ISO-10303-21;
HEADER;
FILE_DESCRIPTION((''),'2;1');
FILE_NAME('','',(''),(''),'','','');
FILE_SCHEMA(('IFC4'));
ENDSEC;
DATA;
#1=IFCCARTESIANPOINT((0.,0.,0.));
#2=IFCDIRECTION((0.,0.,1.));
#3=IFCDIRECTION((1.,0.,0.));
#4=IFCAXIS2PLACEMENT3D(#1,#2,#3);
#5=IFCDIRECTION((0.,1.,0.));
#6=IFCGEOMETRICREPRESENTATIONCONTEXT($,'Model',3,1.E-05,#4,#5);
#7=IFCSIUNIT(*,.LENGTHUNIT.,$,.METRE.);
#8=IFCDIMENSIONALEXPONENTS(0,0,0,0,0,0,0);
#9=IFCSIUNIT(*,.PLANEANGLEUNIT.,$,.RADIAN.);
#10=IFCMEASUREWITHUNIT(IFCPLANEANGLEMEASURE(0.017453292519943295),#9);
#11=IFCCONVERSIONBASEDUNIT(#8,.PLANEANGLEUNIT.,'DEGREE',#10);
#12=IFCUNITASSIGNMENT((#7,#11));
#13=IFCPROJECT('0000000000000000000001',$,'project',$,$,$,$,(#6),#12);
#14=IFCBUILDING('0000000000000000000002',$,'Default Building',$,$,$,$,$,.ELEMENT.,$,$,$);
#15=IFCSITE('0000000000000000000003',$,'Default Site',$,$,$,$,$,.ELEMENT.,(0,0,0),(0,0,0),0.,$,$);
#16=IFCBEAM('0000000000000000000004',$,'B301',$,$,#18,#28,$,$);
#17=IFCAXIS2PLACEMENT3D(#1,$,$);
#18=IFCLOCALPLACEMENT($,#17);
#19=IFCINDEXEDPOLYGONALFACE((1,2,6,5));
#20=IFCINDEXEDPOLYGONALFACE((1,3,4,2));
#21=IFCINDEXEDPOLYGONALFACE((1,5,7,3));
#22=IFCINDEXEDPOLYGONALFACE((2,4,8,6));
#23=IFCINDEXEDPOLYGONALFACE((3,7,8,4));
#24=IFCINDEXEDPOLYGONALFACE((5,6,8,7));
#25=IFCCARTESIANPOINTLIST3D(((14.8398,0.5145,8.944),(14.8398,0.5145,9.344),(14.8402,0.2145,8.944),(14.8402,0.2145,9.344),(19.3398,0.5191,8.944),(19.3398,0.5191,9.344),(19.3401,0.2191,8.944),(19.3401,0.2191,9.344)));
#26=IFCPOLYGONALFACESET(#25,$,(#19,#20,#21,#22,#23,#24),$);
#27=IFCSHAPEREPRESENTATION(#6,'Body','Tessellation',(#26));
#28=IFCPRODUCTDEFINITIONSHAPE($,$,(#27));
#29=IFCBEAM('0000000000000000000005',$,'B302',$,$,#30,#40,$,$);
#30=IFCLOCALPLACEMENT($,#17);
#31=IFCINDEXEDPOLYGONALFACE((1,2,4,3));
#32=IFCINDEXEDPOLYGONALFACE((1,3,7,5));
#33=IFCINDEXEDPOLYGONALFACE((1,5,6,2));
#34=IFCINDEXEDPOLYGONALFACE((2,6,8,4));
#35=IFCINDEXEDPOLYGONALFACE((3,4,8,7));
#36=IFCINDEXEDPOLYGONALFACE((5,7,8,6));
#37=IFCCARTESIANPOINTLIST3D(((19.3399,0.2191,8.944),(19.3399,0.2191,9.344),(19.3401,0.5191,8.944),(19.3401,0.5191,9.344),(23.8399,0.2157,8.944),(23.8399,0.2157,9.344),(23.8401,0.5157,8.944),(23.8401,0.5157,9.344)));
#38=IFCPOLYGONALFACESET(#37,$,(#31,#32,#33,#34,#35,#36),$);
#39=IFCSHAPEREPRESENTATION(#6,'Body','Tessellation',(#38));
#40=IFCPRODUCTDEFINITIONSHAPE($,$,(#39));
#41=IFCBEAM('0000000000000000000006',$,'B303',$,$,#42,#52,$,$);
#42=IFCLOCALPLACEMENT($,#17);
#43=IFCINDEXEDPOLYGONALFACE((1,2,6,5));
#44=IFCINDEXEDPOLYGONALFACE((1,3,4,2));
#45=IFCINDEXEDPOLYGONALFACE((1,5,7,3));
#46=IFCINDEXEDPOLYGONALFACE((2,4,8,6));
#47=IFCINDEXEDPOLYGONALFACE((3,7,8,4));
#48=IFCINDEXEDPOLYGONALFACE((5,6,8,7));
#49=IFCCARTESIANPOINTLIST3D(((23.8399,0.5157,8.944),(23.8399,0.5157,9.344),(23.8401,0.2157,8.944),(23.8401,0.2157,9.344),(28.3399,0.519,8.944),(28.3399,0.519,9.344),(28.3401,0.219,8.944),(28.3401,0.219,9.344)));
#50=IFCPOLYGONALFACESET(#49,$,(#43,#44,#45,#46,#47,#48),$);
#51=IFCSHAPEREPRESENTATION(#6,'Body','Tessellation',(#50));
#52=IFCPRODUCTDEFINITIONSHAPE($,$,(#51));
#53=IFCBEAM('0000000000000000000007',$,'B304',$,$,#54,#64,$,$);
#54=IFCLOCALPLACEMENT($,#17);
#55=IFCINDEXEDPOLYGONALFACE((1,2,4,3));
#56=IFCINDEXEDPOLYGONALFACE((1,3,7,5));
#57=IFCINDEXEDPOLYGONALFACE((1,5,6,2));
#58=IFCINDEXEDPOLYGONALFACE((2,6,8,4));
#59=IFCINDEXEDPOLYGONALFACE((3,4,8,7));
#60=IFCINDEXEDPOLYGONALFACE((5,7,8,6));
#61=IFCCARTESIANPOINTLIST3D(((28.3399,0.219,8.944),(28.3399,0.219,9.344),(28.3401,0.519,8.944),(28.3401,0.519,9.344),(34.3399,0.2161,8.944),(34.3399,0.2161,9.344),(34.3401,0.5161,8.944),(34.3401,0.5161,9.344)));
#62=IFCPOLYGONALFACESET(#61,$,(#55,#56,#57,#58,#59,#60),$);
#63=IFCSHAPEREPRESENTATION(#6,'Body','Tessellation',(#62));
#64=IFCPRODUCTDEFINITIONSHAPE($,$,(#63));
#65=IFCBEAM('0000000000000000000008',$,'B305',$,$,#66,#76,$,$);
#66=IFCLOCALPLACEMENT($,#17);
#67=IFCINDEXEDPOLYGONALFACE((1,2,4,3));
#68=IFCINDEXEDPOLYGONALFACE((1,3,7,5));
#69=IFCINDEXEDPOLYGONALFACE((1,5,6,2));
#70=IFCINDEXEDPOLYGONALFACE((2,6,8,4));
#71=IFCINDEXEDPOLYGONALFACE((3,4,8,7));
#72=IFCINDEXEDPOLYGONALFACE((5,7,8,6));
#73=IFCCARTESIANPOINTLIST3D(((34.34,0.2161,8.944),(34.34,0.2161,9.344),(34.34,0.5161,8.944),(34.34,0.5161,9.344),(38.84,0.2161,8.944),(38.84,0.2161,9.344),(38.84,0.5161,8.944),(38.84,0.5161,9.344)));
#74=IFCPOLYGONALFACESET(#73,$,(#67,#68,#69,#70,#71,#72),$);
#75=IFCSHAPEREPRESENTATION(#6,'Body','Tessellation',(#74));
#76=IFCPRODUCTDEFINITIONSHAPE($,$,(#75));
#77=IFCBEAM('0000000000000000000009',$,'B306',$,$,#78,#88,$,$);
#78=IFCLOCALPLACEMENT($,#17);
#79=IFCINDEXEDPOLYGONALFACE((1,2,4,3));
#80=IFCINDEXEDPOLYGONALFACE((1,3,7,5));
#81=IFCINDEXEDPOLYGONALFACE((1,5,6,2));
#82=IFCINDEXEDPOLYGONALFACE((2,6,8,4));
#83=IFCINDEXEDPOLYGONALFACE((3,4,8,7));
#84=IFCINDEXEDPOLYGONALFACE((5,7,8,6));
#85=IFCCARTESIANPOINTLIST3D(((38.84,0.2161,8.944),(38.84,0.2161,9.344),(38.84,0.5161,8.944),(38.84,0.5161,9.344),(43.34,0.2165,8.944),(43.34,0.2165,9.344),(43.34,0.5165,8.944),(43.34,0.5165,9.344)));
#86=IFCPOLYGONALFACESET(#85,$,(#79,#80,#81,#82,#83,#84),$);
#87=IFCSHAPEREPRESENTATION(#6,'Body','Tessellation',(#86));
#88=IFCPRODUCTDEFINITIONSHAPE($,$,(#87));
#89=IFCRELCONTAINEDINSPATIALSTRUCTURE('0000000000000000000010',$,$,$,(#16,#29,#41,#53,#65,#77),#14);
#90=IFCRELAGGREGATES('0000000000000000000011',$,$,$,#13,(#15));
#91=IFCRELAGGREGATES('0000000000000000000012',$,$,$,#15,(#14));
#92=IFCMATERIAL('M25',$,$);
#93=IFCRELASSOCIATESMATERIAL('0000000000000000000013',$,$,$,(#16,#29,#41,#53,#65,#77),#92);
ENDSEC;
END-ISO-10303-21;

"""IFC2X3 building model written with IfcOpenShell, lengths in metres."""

from ifc_helpers import new_model, entity, si_unit, converted_unit, direction, frame, frame_2d, origin_with_axes, place, context, project, spatial, rectangle, extrude, material, element, save


model = new_model("IFC2X3")

# Units and contexts
model_context = context("Model", 3, precision=1e-05, world=origin_with_axes(), true_north=direction((0.0, 1.0, 0.0)))
ifc_project = project(units=[si_unit("LENGTHUNIT", "METRE"), converted_unit("PLANEANGLEUNIT", "DEGREE", entity("IfcPlaneAngleMeasure", 0.017453292519943295), si_unit("PLANEANGLEUNIT", "RADIAN"), dimensions=[0, 0, 0, 0, 0, 0, 0])], contexts=[model_context])

# Site, building
site = spatial("IfcSite", under=ifc_project, Name="Default Site", CompositionType="ELEMENT", RefLatitude=(0, 0, 0), RefLongitude=(0, 0, 0), RefElevation=0.0)
building = spatial("IfcBuilding", under=site, Name="Default Building", CompositionType="ELEMENT")

# Shared definitions
ifc_material = material(Name="M25")
placement = place(None, origin_with_axes())

# Beams
element("IfcBeam", 1, at=placement, inside=building, material=ifc_material, Name="B301", context=model_context, shape_type="SweptSolid", body=[
    extrude(rectangle(XDim=0.3, YDim=0.4, at=frame_2d((0.0, 0.0), x_axis=(0.0, 1.0, 0.0))), frame((14.84, 0.3645, 9.144), z_axis=(0.999999, 0.00101, 0.0), x_axis=(0.0, 0.0, -1.0)), (0.0, 0.0, 1.0), 4.5),
])
element("IfcBeam", 2, at=placement, inside=building, material=ifc_material, Name="B302", context=model_context, shape_type="SweptSolid", body=[
    extrude(rectangle(XDim=0.3, YDim=0.4, at=frame_2d((0.0, 0.0), x_axis=(0.0, 1.0, 0.0))), frame((19.34, 0.3691, 9.144), z_axis=(1.0, -0.000757, 0.0), x_axis=(0.0, 0.0, -1.0)), (0.0, 0.0, 1.0), 4.5),
])
element("IfcBeam", 3, at=placement, inside=building, material=ifc_material, Name="B303", context=model_context, shape_type="SweptSolid", body=[
    extrude(rectangle(XDim=0.3, YDim=0.4, at=frame_2d((0.0, 0.0), x_axis=(0.0, 1.0, 0.0))), frame((23.84, 0.3657, 9.144), z_axis=(1.0, 0.00075, 0.0), x_axis=(0.0, 0.0, -1.0)), (0.0, 0.0, 1.0), 4.5),
])
element("IfcBeam", 4, at=placement, inside=building, material=ifc_material, Name="B304", context=model_context, shape_type="SweptSolid", body=[
    extrude(rectangle(XDim=0.3, YDim=0.4, at=frame_2d((0.0, 0.0), x_axis=(0.0, 1.0, 0.0))), frame((28.34, 0.369, 9.144), z_axis=(1.0, -0.000487, 0.0), x_axis=(0.0, 0.0, -1.0)), (0.0, 0.0, 1.0), 6.0),
])
element("IfcBeam", 5, at=placement, inside=building, material=ifc_material, Name="B305", context=model_context, shape_type="SweptSolid", body=[
    extrude(rectangle(XDim=0.3, YDim=0.4, at=frame_2d((0.0, 0.0), x_axis=(0.0, 1.0, 0.0))), frame((34.34, 0.3661, 9.144), z_axis=(1.0, 0.000003, 0.0), x_axis=(0.0, 0.0, -1.0)), (0.0, 0.0, 1.0), 4.5),
])
element("IfcBeam", 6, at=placement, inside=building, material=ifc_material, Name="B306", context=model_context, shape_type="SweptSolid", body=[
    extrude(rectangle(XDim=0.3, YDim=0.4, at=frame_2d((0.0, 0.0), x_axis=(0.0, 1.0, 0.0))), frame((38.84, 0.3661, 9.144), z_axis=(1.0, 0.000077, 0.0), x_axis=(0.0, 0.0, -1.0)), (0.0, 0.0, 1.0), 4.5),
])

save(model, "model.ifc")
